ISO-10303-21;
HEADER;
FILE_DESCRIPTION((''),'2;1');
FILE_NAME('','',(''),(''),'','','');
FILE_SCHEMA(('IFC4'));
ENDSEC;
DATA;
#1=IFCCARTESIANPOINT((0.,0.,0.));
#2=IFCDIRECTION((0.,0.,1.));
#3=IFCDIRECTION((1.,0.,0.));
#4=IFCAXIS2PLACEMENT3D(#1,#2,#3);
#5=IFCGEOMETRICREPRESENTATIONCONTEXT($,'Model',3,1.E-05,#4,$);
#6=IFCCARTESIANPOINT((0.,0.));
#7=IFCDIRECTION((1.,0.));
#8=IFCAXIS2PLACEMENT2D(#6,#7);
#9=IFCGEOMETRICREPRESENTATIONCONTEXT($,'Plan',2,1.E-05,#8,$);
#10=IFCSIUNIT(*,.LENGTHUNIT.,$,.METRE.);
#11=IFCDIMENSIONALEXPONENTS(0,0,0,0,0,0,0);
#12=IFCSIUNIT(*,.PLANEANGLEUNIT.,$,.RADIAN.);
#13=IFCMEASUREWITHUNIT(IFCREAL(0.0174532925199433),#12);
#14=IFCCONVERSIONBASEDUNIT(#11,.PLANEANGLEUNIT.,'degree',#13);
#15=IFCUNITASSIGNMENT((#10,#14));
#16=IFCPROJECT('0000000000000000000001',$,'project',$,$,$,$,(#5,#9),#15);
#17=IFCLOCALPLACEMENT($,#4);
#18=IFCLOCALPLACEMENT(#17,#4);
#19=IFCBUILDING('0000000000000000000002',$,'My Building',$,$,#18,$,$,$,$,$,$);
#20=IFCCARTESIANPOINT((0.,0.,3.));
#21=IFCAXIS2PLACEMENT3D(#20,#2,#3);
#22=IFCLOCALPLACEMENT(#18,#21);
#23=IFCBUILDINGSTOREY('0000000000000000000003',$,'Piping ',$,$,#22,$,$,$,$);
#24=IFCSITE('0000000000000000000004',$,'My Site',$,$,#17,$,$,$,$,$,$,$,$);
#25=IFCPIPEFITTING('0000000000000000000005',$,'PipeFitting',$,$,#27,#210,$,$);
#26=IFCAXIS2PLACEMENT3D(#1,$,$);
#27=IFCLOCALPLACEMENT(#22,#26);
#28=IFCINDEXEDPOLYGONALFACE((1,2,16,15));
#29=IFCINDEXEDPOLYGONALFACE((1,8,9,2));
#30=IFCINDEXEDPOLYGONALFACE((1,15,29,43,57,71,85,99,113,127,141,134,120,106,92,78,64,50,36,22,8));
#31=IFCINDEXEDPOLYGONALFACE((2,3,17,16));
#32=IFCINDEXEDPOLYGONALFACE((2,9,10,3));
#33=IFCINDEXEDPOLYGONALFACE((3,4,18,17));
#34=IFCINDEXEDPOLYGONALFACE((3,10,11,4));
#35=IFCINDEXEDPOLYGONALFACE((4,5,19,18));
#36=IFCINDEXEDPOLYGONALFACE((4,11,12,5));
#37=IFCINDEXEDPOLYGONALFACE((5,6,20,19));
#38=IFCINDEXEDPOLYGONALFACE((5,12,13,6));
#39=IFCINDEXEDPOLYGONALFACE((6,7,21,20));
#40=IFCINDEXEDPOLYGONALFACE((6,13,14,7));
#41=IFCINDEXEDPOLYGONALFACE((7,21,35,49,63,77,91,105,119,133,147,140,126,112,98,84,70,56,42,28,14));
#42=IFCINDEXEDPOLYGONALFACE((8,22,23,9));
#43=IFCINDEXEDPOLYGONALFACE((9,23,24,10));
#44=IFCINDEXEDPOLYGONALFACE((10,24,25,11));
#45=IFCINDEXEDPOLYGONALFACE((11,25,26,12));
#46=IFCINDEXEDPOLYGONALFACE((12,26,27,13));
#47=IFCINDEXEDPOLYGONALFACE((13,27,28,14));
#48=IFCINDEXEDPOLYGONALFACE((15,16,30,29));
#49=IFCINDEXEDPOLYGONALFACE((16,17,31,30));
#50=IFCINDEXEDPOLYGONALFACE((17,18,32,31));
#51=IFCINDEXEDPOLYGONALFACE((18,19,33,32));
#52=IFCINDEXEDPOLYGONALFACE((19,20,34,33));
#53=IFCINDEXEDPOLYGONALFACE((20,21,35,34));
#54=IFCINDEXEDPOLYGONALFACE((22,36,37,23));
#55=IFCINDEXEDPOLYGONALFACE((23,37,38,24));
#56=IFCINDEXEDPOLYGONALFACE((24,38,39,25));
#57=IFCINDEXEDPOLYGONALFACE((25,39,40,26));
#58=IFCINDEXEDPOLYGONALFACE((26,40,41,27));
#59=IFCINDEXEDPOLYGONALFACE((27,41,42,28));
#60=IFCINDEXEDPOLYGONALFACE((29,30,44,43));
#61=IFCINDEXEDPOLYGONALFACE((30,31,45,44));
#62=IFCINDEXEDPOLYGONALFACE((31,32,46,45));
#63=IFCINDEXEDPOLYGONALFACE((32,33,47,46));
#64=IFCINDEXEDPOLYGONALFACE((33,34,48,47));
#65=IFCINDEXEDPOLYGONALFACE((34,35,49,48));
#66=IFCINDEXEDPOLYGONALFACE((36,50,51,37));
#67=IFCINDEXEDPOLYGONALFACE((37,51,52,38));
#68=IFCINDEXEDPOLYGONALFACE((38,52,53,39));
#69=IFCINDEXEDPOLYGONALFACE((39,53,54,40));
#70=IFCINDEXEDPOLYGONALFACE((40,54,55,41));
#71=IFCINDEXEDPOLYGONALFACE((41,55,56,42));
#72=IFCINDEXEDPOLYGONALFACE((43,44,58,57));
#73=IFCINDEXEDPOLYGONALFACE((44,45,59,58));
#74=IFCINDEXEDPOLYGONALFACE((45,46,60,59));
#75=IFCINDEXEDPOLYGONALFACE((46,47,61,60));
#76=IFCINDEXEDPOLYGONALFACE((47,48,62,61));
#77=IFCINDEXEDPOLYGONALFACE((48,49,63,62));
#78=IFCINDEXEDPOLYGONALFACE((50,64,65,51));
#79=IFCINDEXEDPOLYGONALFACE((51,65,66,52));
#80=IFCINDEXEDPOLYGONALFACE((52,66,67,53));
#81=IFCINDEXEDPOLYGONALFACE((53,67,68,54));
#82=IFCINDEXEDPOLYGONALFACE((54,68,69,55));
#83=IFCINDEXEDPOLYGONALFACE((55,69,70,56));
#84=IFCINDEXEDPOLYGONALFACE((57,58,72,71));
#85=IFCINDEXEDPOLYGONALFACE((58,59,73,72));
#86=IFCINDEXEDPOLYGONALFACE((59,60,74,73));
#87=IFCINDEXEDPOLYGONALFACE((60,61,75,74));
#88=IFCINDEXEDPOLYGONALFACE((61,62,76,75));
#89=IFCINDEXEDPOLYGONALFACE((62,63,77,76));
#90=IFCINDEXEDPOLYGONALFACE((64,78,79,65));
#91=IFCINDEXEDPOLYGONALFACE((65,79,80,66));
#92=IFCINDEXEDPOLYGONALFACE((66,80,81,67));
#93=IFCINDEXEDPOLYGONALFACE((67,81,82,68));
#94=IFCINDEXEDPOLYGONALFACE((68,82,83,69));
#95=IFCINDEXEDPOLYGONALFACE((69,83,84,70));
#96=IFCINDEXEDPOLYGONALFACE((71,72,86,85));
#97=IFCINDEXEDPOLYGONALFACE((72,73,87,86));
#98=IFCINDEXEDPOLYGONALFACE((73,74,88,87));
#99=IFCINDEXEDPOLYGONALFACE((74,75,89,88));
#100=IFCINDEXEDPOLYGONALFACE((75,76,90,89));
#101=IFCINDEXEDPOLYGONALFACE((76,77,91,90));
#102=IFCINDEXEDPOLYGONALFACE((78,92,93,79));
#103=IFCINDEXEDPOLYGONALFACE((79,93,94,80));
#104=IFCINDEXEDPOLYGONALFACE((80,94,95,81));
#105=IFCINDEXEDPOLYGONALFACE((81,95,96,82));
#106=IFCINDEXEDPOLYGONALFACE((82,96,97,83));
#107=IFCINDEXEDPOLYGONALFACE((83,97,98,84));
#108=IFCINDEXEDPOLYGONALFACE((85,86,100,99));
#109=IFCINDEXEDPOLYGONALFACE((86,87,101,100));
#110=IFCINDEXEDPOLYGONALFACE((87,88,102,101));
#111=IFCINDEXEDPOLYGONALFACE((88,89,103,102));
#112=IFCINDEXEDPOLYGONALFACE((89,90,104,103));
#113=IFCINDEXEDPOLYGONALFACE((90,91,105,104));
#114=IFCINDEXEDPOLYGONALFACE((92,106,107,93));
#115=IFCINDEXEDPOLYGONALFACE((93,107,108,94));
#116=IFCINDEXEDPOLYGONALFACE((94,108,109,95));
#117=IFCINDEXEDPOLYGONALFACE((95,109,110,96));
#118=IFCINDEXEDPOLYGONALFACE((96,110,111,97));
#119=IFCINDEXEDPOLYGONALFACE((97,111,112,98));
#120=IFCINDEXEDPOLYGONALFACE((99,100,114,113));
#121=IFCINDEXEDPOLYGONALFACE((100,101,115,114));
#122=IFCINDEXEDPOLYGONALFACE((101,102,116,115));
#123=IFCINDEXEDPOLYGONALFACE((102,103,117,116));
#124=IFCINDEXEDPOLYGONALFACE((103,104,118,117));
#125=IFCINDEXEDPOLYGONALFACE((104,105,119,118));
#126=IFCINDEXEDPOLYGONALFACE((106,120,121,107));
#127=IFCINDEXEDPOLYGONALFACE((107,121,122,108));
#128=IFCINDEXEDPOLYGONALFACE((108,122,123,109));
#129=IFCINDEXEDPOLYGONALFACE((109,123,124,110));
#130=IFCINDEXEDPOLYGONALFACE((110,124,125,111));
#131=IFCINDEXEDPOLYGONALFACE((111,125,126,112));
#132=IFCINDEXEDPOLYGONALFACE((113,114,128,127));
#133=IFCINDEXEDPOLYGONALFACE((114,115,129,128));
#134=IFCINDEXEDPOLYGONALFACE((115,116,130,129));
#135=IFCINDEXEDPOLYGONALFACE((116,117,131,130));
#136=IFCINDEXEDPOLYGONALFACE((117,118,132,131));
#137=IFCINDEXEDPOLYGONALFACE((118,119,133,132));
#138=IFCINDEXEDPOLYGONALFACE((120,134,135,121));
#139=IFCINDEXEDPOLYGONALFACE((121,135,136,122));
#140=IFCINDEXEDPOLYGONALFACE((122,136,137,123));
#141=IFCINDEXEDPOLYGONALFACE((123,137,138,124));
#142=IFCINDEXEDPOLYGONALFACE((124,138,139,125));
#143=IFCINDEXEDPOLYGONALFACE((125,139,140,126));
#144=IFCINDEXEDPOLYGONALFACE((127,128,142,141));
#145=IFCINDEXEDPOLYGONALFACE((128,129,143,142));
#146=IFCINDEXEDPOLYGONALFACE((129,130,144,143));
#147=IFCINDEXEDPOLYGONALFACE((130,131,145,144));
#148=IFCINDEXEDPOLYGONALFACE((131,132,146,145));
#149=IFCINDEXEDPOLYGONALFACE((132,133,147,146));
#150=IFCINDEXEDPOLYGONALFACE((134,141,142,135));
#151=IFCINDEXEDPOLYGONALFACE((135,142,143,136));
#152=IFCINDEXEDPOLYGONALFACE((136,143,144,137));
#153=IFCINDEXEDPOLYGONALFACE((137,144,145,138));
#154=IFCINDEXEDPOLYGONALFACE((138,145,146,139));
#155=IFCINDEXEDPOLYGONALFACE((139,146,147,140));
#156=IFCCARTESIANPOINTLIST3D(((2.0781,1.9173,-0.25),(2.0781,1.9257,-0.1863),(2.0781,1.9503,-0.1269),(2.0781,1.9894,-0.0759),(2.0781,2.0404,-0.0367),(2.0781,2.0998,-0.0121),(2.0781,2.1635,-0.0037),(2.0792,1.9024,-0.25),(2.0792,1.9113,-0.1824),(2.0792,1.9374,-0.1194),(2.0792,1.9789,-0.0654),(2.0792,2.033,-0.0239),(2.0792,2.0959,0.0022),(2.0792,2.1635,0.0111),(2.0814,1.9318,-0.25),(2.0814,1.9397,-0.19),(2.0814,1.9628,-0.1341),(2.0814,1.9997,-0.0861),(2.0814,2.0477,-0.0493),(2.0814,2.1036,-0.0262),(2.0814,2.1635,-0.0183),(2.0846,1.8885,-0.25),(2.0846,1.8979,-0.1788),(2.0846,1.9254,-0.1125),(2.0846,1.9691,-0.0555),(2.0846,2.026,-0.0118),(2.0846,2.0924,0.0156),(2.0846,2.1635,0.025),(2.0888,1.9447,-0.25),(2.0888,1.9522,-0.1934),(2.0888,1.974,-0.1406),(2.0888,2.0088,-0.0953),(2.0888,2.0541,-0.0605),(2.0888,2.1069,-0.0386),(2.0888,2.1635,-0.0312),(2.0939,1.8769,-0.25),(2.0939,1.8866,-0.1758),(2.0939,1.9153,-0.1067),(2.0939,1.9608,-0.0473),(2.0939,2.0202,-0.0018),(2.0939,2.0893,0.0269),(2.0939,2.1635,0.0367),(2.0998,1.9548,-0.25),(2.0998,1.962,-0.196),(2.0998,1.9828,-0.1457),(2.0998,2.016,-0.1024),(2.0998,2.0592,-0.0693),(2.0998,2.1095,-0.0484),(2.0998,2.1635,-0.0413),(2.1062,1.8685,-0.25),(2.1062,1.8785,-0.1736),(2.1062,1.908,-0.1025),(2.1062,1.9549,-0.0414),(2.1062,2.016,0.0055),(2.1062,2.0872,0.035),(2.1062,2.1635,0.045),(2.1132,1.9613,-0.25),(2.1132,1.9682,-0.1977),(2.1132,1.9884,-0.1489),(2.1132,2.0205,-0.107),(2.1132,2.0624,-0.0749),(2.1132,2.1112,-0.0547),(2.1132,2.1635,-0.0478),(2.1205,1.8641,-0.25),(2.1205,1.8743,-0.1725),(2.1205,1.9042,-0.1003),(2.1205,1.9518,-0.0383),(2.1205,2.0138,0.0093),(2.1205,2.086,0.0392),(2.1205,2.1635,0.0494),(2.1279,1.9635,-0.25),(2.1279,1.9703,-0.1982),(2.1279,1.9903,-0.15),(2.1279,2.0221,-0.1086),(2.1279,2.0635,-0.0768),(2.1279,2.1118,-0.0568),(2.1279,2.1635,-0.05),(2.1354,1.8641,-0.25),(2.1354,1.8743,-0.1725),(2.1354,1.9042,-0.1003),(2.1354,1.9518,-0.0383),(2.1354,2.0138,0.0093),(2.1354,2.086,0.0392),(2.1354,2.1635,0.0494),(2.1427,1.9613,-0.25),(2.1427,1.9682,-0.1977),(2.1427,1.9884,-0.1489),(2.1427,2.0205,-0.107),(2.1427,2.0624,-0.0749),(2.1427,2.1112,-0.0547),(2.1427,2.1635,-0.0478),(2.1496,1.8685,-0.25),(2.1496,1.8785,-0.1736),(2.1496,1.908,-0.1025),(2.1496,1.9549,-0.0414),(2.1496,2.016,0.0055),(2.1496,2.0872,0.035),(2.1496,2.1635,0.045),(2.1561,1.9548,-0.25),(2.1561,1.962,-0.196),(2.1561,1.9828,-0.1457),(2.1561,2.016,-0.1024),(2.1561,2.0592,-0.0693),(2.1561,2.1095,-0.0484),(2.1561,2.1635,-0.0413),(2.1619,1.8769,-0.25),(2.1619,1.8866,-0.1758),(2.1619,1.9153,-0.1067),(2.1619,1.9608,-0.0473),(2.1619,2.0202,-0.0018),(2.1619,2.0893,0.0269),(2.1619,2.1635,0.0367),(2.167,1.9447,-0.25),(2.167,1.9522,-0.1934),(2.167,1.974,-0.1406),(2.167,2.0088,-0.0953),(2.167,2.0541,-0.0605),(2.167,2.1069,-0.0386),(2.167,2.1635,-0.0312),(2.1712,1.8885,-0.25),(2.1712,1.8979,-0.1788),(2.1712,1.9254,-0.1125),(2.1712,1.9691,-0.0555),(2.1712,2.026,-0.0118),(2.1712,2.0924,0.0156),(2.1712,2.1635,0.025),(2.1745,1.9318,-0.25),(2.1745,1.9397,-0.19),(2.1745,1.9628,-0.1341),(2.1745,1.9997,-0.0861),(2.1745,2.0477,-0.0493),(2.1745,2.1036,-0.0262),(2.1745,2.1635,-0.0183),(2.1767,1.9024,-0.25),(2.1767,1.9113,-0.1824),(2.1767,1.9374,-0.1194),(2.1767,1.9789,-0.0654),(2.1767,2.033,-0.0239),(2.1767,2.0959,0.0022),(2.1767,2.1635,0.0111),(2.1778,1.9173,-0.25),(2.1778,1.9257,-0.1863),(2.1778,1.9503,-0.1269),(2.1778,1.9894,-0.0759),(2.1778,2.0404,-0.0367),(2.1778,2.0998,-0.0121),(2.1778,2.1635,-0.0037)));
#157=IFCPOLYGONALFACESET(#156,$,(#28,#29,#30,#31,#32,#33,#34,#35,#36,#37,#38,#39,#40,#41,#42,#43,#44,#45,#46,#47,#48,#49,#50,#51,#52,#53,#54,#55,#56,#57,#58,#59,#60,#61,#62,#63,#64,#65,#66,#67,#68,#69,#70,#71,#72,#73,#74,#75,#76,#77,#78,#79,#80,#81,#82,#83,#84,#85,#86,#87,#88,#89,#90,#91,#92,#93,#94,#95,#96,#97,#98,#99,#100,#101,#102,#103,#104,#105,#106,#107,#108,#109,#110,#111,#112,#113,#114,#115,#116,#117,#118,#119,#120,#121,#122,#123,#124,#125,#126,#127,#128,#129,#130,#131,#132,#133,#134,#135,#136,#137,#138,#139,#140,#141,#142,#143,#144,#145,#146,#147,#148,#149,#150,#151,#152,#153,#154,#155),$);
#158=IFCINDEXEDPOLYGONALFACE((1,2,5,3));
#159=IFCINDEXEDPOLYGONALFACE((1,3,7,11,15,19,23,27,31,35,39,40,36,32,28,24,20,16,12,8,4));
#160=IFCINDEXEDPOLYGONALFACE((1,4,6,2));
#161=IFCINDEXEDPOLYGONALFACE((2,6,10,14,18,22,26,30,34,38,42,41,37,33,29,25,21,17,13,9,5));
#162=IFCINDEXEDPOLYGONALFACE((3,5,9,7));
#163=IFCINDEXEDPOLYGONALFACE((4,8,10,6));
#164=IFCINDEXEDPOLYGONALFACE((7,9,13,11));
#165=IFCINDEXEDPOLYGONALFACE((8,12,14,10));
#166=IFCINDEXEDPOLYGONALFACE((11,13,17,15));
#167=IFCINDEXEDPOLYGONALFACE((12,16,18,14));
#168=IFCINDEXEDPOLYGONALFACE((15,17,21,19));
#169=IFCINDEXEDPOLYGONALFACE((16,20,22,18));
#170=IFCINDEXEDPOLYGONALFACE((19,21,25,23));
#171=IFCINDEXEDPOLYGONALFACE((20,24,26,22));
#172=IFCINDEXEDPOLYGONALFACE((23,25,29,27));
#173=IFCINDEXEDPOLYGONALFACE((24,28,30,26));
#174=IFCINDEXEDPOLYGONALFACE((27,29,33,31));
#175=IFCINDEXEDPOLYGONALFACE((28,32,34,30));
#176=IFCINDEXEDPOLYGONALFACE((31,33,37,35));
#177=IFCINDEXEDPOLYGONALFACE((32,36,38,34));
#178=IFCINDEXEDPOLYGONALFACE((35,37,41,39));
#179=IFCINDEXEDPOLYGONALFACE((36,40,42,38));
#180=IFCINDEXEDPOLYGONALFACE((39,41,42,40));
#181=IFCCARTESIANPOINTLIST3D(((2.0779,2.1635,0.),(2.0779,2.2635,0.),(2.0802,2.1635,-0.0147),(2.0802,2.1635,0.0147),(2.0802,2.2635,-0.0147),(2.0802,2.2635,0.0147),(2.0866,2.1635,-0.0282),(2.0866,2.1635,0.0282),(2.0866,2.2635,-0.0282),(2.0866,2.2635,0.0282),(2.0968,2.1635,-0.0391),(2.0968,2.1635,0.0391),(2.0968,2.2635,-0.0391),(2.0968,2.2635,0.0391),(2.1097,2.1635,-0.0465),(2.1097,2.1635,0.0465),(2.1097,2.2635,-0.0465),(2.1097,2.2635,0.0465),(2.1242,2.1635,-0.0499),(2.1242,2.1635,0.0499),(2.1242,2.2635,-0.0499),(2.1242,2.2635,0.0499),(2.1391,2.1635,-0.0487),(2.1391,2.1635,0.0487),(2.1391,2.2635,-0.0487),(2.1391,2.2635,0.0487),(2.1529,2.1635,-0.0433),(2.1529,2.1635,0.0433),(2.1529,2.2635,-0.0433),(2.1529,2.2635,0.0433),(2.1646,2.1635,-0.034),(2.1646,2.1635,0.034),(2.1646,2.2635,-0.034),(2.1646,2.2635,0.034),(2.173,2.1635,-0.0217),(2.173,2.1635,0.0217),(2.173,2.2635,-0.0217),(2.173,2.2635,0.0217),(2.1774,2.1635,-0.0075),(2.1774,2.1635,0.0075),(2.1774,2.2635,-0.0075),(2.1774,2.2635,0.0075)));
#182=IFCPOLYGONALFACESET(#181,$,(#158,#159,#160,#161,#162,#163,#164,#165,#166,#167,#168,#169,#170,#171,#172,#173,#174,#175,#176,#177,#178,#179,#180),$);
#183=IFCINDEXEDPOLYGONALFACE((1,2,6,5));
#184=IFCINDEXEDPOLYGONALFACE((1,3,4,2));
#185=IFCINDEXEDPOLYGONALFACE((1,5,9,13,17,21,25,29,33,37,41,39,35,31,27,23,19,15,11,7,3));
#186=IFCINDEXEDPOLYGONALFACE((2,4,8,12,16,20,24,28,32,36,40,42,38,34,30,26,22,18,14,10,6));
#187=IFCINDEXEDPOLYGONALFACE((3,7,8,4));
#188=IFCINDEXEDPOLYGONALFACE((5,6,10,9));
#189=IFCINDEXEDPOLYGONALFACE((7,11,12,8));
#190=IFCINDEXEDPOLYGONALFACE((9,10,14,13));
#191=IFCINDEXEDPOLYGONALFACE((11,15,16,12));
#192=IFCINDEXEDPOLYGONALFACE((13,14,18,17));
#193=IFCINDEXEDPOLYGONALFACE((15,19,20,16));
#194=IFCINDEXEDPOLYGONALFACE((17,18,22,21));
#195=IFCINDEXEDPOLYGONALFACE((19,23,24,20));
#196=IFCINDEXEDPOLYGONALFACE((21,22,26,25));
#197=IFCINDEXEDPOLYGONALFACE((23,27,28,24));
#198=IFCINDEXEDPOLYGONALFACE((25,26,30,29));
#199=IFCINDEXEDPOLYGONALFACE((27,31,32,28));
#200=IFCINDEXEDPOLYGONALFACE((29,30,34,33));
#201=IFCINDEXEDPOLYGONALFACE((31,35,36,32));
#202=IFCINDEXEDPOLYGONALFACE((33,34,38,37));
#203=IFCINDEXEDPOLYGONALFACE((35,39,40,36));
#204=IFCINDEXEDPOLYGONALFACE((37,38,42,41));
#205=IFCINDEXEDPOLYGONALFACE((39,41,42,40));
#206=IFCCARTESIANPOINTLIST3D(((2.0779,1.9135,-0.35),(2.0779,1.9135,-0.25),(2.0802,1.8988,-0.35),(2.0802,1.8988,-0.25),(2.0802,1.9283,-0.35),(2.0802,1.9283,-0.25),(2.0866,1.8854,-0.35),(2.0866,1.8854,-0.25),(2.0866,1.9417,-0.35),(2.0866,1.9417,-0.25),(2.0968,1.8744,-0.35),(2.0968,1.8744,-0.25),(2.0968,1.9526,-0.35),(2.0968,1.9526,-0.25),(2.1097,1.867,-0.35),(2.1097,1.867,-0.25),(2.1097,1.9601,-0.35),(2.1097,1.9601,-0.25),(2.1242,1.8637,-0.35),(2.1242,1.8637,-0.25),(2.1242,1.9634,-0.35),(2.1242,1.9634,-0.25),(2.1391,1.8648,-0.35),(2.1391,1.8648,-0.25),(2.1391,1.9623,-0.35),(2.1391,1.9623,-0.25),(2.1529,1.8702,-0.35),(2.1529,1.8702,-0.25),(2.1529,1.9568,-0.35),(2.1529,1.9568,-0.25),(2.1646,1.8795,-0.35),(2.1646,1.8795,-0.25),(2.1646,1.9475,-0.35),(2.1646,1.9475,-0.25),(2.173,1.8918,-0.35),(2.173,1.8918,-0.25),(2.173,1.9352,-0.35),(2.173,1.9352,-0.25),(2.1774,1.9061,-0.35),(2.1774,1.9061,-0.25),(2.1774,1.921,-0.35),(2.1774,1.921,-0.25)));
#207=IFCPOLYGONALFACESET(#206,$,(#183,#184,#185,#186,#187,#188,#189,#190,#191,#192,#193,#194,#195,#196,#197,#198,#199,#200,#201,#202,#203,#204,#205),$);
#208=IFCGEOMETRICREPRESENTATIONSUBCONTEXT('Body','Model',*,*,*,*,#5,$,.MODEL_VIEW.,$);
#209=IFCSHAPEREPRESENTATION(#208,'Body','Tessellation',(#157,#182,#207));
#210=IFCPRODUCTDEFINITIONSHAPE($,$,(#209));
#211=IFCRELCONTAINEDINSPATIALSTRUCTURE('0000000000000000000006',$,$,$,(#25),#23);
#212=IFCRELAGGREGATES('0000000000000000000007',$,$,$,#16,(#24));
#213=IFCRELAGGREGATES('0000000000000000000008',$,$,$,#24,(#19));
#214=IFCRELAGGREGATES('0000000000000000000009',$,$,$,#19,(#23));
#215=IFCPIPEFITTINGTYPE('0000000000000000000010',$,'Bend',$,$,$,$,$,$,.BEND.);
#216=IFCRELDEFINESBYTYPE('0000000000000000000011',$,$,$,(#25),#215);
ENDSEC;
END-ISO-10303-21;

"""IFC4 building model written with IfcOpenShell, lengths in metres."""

from ifc_helpers import new_model, entity, si_unit, converted_unit, frame, origin_with_axes, origin_2d_with_axis, place, context, subcontext, project, spatial, circle, extrude, source, transform, mapped, type_object, type_shapes, element, save


model = new_model("IFC4")

# Units and contexts
model_context = context("Model", 3, precision=1e-05, world=origin_with_axes())
plan_context = context("Plan", 2, precision=1e-05, world=origin_2d_with_axis())
body_context = subcontext(model_context, "Body", "Model", "MODEL_VIEW")
ifc_project = project(units=[si_unit("LENGTHUNIT", "METRE"), converted_unit("PLANEANGLEUNIT", "degree", entity("IfcReal", 0.0174532925199433), si_unit("PLANEANGLEUNIT", "RADIAN"), dimensions=[0, 0, 0, 0, 0, 0, 0])], contexts=[model_context, plan_context])

# Site, building, storey
site_placement = place(None, origin_with_axes())
site = spatial("IfcSite", under=ifc_project, at=site_placement, Name="My Site")
building_placement = place(site_placement, origin_with_axes())
building = spatial("IfcBuilding", under=site, at=building_placement, Name="My Building")
storey_placement = place(building_placement, frame((0.0, 0.0, 3.0), z_axis=(0.0, 0.0, 1.0), x_axis=(1.0, 0.0, 0.0)))
storey = spatial("IfcBuildingStorey", under=building, at=storey_placement, Name="Piping ")

# Pipe fitting
pipe_fitting_type = type_object("IfcPipeFittingType", Name="Bend", PredefinedType="BEND")
shared_shape = source(origin_with_axes(), body_context, "Body", "SolidModel", [
    entity("IfcSweptDiskSolid", entity("IfcIndexedPolyCurve", entity("IfcCartesianPointList3D", [[0.0, 0.0, -0.1], [0.0, -0.0732, -0.2768], [0.0, -0.25, -0.35]]), [entity("IfcArcIndex", [1, 2, 3])]), 0.05),
    extrude(circle(Radius=0.05), origin_with_axes(), (0.0, 0.0, -1.0), 0.1),
    extrude(circle(Radius=0.05), frame((0.0, -0.25, -0.35), z_axis=(0.0, -1.0, 0.0), x_axis=(1.0, 0.0, 0.0)), (0.0, 0.0, 1.0), 0.1),
])
type_shapes(pipe_fitting_type, [shared_shape])
for number, where, z_axis, x_axis, name in (
    (1, (2.1279, 2.2635, 0.0), (0.0, 1.0, 0.0), (-1.0, 0.0, 0.0), "PipeFitting"),
):
    element("IfcPipeFitting", number, at=place(storey_placement, frame(where, z_axis=z_axis, x_axis=x_axis)), inside=storey, type_object=pipe_fitting_type, Name=name, context=body_context, shape_type="MappedRepresentation", body=[
        mapped(shared_shape, transform((0.0, 0.0, 0.0), x_axis=(1.0, 0.0, 0.0), y_axis=(0.0, 1.0, 0.0), z_axis=(0.0, 0.0, 1.0), scale=1.0)),
    ])

save(model, "model.ifc")
